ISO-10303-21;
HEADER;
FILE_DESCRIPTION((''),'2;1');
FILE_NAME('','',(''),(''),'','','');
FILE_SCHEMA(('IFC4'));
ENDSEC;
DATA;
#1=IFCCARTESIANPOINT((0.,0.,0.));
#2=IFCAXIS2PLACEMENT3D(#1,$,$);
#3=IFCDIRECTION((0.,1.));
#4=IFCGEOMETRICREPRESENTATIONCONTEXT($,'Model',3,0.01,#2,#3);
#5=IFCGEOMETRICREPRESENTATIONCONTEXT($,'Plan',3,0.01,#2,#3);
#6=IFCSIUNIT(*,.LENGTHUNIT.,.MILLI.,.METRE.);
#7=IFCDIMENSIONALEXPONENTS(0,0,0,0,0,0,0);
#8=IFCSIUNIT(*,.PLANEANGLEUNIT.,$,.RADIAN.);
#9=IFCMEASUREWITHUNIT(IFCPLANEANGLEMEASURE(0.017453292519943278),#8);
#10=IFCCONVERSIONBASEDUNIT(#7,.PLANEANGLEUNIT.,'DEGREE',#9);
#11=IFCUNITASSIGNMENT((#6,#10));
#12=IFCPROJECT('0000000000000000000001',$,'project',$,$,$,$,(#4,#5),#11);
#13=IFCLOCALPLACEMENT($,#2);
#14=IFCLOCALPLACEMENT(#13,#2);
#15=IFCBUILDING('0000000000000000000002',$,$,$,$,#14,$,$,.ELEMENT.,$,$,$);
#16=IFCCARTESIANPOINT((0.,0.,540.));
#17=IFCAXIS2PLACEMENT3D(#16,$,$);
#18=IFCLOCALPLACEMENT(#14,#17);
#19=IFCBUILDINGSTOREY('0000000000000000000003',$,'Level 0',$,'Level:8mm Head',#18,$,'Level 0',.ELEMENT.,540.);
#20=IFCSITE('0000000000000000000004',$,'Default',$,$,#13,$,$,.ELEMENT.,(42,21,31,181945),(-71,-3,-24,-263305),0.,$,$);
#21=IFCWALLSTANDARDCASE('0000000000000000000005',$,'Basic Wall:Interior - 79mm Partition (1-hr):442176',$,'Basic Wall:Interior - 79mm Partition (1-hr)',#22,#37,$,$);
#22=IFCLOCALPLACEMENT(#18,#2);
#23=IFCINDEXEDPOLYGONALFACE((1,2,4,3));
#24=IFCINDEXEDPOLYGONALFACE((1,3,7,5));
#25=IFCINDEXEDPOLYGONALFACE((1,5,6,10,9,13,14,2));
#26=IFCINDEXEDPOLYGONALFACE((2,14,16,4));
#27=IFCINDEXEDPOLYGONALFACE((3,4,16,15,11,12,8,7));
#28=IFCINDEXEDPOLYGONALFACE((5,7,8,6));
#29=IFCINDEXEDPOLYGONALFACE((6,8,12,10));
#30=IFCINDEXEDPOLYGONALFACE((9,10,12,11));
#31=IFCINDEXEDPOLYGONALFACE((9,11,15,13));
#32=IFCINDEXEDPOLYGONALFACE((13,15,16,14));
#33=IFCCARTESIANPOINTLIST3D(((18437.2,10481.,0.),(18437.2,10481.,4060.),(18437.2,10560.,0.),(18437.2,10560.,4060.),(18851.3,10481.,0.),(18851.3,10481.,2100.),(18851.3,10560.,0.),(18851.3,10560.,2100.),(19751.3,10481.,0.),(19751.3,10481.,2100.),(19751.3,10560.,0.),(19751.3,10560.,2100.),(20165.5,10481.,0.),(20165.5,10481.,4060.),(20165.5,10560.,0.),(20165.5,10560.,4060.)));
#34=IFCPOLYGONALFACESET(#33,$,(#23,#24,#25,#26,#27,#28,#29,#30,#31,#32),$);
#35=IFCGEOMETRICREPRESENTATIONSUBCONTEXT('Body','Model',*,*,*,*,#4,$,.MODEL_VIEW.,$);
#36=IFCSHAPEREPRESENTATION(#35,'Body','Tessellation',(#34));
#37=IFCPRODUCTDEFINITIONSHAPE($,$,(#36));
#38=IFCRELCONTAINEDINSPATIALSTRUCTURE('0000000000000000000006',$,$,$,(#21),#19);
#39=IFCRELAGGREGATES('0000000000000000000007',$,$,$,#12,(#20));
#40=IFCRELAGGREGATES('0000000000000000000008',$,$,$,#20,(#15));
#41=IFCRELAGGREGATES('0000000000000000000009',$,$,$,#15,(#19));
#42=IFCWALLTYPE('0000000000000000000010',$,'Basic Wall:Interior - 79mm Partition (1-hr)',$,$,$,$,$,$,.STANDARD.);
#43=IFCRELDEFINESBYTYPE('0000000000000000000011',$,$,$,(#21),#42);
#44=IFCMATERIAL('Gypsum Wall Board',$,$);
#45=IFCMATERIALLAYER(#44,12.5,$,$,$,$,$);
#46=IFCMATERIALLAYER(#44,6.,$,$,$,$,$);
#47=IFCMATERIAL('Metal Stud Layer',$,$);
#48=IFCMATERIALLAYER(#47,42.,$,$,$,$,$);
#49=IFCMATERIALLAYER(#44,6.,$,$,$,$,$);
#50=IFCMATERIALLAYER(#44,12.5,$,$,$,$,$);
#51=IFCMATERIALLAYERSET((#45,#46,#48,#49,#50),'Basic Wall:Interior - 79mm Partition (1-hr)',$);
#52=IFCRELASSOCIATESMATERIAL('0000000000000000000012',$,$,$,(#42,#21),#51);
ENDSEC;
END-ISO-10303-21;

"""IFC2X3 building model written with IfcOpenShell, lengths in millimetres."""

from ifc_helpers import new_model, entity, si_unit, converted_unit, direction, frame, frame_2d, origin, place, context, subcontext, project, spatial, polyline, rectangle, extrude, clip, bounded_halfspace, material, layer, layer_set, layer_usage, type_object, element, save


model = new_model("IFC2X3")

# Units and contexts
model_context = context("Model", 3, precision=0.01, world=origin(), true_north=direction((0.0, 1.0)))
plan_context = context("Plan", 3, precision=0.01, world=origin(), true_north=direction((0.0, 1.0)))
body_context = subcontext(model_context, "Body", "Model", "MODEL_VIEW")
ifc_project = project(units=[si_unit("LENGTHUNIT", "METRE", prefix="MILLI"), converted_unit("PLANEANGLEUNIT", "DEGREE", entity("IfcPlaneAngleMeasure", 0.017453292519943278), si_unit("PLANEANGLEUNIT", "RADIAN"), dimensions=[0, 0, 0, 0, 0, 0, 0])], contexts=[model_context, plan_context])

# Site, building, storey
site_placement = place(None, origin())
site = spatial("IfcSite", under=ifc_project, at=site_placement, Name="Default", CompositionType="ELEMENT", RefLatitude=(42, 21, 31, 181945), RefLongitude=(-71, -3, -24, -263305), RefElevation=0.0)
building_placement = place(site_placement, origin())
building = spatial("IfcBuilding", under=site, at=building_placement, CompositionType="ELEMENT")
storey_placement = place(building_placement, frame((0.0, 0.0, 540.0)))
storey = spatial("IfcBuildingStorey", under=building, at=storey_placement, Name="Level 0", ObjectType="Level:8mm Head", LongName="Level 0", CompositionType="ELEMENT", Elevation=540.0)

# Shared definitions
ifc_material_1 = material(Name="Gypsum Wall Board")
ifc_layer_1 = layer(ifc_material_1, 12.5)
ifc_layer_2 = layer(ifc_material_1, 6.0)
ifc_material_2 = material(Name="Metal Stud Layer")
ifc_layer_3 = layer(ifc_material_2, 42.0)
ifc_layer_4 = layer(ifc_material_1, 6.0)
ifc_layer_5 = layer(ifc_material_1, 12.5)
ifc_layer_set_1 = layer_set([ifc_layer_1, ifc_layer_2, ifc_layer_3, ifc_layer_4, ifc_layer_5], Name="Basic Wall:Interior - 79mm Partition (1-hr)")
ifc_layer_usage_1 = layer_usage(ifc_layer_set_1, "AXIS2", "NEGATIVE", 39.5)
wall_type_1 = type_object("IfcWallType", Name="Basic Wall:Interior - 79mm Partition (1-hr)", PredefinedType="STANDARD", material=ifc_layer_set_1)

# Wall, opening
wall_1_placement = place(storey_placement, frame((18437.2, 10520.5, 0.0)))
wall_1 = element("IfcWallStandardCase", 1, at=wall_1_placement, inside=storey, type_object=wall_type_1, material=ifc_layer_usage_1, Name="Basic Wall:Interior - 79mm Partition (1-hr):442176", ObjectType="Basic Wall:Interior - 79mm Partition (1-hr)", context=body_context, shape_type="Clipping", body=[
    clip(extrude(rectangle(XDim=1728.3, YDim=79.0, at=frame_2d((864.2, 0.0), x_axis=(1.0, 0.0))), origin(), (0.0, 0.0, 1.0), 4060.0), bounded_halfspace(frame((0.0, -39.5, 4060.0), z_axis=(0.0, 0.0, -1.0), x_axis=(0.0, -1.0, 0.0)), True, frame((0.0, -39.5, 4060.0)), polyline([(0.0, 0.0), (1728.3, 0.0), (1728.3, 79.0), (0.0, 79.0), (0.0, 0.0)]))),
])
opening_1_placement = place(wall_1_placement, frame((1314.2, 39.5, 0.0)))
element("IfcOpeningElement", 2, at=opening_1_placement, cuts=wall_1, ObjectType="Opening", context=body_context, shape_type="SweptSolid", body=[
    extrude(rectangle(XDim=2100.0, YDim=900.0, at=frame_2d((1050.0, 450.0), x_axis=(1.0, 0.0))), frame((0.0, 0.0, 0.0), z_axis=(0.0, -1.0, 0.0), x_axis=(0.0, 0.0, 1.0)), (0.0, 0.0, 1.0), 79.0),
])

save(model, "model.ifc")
